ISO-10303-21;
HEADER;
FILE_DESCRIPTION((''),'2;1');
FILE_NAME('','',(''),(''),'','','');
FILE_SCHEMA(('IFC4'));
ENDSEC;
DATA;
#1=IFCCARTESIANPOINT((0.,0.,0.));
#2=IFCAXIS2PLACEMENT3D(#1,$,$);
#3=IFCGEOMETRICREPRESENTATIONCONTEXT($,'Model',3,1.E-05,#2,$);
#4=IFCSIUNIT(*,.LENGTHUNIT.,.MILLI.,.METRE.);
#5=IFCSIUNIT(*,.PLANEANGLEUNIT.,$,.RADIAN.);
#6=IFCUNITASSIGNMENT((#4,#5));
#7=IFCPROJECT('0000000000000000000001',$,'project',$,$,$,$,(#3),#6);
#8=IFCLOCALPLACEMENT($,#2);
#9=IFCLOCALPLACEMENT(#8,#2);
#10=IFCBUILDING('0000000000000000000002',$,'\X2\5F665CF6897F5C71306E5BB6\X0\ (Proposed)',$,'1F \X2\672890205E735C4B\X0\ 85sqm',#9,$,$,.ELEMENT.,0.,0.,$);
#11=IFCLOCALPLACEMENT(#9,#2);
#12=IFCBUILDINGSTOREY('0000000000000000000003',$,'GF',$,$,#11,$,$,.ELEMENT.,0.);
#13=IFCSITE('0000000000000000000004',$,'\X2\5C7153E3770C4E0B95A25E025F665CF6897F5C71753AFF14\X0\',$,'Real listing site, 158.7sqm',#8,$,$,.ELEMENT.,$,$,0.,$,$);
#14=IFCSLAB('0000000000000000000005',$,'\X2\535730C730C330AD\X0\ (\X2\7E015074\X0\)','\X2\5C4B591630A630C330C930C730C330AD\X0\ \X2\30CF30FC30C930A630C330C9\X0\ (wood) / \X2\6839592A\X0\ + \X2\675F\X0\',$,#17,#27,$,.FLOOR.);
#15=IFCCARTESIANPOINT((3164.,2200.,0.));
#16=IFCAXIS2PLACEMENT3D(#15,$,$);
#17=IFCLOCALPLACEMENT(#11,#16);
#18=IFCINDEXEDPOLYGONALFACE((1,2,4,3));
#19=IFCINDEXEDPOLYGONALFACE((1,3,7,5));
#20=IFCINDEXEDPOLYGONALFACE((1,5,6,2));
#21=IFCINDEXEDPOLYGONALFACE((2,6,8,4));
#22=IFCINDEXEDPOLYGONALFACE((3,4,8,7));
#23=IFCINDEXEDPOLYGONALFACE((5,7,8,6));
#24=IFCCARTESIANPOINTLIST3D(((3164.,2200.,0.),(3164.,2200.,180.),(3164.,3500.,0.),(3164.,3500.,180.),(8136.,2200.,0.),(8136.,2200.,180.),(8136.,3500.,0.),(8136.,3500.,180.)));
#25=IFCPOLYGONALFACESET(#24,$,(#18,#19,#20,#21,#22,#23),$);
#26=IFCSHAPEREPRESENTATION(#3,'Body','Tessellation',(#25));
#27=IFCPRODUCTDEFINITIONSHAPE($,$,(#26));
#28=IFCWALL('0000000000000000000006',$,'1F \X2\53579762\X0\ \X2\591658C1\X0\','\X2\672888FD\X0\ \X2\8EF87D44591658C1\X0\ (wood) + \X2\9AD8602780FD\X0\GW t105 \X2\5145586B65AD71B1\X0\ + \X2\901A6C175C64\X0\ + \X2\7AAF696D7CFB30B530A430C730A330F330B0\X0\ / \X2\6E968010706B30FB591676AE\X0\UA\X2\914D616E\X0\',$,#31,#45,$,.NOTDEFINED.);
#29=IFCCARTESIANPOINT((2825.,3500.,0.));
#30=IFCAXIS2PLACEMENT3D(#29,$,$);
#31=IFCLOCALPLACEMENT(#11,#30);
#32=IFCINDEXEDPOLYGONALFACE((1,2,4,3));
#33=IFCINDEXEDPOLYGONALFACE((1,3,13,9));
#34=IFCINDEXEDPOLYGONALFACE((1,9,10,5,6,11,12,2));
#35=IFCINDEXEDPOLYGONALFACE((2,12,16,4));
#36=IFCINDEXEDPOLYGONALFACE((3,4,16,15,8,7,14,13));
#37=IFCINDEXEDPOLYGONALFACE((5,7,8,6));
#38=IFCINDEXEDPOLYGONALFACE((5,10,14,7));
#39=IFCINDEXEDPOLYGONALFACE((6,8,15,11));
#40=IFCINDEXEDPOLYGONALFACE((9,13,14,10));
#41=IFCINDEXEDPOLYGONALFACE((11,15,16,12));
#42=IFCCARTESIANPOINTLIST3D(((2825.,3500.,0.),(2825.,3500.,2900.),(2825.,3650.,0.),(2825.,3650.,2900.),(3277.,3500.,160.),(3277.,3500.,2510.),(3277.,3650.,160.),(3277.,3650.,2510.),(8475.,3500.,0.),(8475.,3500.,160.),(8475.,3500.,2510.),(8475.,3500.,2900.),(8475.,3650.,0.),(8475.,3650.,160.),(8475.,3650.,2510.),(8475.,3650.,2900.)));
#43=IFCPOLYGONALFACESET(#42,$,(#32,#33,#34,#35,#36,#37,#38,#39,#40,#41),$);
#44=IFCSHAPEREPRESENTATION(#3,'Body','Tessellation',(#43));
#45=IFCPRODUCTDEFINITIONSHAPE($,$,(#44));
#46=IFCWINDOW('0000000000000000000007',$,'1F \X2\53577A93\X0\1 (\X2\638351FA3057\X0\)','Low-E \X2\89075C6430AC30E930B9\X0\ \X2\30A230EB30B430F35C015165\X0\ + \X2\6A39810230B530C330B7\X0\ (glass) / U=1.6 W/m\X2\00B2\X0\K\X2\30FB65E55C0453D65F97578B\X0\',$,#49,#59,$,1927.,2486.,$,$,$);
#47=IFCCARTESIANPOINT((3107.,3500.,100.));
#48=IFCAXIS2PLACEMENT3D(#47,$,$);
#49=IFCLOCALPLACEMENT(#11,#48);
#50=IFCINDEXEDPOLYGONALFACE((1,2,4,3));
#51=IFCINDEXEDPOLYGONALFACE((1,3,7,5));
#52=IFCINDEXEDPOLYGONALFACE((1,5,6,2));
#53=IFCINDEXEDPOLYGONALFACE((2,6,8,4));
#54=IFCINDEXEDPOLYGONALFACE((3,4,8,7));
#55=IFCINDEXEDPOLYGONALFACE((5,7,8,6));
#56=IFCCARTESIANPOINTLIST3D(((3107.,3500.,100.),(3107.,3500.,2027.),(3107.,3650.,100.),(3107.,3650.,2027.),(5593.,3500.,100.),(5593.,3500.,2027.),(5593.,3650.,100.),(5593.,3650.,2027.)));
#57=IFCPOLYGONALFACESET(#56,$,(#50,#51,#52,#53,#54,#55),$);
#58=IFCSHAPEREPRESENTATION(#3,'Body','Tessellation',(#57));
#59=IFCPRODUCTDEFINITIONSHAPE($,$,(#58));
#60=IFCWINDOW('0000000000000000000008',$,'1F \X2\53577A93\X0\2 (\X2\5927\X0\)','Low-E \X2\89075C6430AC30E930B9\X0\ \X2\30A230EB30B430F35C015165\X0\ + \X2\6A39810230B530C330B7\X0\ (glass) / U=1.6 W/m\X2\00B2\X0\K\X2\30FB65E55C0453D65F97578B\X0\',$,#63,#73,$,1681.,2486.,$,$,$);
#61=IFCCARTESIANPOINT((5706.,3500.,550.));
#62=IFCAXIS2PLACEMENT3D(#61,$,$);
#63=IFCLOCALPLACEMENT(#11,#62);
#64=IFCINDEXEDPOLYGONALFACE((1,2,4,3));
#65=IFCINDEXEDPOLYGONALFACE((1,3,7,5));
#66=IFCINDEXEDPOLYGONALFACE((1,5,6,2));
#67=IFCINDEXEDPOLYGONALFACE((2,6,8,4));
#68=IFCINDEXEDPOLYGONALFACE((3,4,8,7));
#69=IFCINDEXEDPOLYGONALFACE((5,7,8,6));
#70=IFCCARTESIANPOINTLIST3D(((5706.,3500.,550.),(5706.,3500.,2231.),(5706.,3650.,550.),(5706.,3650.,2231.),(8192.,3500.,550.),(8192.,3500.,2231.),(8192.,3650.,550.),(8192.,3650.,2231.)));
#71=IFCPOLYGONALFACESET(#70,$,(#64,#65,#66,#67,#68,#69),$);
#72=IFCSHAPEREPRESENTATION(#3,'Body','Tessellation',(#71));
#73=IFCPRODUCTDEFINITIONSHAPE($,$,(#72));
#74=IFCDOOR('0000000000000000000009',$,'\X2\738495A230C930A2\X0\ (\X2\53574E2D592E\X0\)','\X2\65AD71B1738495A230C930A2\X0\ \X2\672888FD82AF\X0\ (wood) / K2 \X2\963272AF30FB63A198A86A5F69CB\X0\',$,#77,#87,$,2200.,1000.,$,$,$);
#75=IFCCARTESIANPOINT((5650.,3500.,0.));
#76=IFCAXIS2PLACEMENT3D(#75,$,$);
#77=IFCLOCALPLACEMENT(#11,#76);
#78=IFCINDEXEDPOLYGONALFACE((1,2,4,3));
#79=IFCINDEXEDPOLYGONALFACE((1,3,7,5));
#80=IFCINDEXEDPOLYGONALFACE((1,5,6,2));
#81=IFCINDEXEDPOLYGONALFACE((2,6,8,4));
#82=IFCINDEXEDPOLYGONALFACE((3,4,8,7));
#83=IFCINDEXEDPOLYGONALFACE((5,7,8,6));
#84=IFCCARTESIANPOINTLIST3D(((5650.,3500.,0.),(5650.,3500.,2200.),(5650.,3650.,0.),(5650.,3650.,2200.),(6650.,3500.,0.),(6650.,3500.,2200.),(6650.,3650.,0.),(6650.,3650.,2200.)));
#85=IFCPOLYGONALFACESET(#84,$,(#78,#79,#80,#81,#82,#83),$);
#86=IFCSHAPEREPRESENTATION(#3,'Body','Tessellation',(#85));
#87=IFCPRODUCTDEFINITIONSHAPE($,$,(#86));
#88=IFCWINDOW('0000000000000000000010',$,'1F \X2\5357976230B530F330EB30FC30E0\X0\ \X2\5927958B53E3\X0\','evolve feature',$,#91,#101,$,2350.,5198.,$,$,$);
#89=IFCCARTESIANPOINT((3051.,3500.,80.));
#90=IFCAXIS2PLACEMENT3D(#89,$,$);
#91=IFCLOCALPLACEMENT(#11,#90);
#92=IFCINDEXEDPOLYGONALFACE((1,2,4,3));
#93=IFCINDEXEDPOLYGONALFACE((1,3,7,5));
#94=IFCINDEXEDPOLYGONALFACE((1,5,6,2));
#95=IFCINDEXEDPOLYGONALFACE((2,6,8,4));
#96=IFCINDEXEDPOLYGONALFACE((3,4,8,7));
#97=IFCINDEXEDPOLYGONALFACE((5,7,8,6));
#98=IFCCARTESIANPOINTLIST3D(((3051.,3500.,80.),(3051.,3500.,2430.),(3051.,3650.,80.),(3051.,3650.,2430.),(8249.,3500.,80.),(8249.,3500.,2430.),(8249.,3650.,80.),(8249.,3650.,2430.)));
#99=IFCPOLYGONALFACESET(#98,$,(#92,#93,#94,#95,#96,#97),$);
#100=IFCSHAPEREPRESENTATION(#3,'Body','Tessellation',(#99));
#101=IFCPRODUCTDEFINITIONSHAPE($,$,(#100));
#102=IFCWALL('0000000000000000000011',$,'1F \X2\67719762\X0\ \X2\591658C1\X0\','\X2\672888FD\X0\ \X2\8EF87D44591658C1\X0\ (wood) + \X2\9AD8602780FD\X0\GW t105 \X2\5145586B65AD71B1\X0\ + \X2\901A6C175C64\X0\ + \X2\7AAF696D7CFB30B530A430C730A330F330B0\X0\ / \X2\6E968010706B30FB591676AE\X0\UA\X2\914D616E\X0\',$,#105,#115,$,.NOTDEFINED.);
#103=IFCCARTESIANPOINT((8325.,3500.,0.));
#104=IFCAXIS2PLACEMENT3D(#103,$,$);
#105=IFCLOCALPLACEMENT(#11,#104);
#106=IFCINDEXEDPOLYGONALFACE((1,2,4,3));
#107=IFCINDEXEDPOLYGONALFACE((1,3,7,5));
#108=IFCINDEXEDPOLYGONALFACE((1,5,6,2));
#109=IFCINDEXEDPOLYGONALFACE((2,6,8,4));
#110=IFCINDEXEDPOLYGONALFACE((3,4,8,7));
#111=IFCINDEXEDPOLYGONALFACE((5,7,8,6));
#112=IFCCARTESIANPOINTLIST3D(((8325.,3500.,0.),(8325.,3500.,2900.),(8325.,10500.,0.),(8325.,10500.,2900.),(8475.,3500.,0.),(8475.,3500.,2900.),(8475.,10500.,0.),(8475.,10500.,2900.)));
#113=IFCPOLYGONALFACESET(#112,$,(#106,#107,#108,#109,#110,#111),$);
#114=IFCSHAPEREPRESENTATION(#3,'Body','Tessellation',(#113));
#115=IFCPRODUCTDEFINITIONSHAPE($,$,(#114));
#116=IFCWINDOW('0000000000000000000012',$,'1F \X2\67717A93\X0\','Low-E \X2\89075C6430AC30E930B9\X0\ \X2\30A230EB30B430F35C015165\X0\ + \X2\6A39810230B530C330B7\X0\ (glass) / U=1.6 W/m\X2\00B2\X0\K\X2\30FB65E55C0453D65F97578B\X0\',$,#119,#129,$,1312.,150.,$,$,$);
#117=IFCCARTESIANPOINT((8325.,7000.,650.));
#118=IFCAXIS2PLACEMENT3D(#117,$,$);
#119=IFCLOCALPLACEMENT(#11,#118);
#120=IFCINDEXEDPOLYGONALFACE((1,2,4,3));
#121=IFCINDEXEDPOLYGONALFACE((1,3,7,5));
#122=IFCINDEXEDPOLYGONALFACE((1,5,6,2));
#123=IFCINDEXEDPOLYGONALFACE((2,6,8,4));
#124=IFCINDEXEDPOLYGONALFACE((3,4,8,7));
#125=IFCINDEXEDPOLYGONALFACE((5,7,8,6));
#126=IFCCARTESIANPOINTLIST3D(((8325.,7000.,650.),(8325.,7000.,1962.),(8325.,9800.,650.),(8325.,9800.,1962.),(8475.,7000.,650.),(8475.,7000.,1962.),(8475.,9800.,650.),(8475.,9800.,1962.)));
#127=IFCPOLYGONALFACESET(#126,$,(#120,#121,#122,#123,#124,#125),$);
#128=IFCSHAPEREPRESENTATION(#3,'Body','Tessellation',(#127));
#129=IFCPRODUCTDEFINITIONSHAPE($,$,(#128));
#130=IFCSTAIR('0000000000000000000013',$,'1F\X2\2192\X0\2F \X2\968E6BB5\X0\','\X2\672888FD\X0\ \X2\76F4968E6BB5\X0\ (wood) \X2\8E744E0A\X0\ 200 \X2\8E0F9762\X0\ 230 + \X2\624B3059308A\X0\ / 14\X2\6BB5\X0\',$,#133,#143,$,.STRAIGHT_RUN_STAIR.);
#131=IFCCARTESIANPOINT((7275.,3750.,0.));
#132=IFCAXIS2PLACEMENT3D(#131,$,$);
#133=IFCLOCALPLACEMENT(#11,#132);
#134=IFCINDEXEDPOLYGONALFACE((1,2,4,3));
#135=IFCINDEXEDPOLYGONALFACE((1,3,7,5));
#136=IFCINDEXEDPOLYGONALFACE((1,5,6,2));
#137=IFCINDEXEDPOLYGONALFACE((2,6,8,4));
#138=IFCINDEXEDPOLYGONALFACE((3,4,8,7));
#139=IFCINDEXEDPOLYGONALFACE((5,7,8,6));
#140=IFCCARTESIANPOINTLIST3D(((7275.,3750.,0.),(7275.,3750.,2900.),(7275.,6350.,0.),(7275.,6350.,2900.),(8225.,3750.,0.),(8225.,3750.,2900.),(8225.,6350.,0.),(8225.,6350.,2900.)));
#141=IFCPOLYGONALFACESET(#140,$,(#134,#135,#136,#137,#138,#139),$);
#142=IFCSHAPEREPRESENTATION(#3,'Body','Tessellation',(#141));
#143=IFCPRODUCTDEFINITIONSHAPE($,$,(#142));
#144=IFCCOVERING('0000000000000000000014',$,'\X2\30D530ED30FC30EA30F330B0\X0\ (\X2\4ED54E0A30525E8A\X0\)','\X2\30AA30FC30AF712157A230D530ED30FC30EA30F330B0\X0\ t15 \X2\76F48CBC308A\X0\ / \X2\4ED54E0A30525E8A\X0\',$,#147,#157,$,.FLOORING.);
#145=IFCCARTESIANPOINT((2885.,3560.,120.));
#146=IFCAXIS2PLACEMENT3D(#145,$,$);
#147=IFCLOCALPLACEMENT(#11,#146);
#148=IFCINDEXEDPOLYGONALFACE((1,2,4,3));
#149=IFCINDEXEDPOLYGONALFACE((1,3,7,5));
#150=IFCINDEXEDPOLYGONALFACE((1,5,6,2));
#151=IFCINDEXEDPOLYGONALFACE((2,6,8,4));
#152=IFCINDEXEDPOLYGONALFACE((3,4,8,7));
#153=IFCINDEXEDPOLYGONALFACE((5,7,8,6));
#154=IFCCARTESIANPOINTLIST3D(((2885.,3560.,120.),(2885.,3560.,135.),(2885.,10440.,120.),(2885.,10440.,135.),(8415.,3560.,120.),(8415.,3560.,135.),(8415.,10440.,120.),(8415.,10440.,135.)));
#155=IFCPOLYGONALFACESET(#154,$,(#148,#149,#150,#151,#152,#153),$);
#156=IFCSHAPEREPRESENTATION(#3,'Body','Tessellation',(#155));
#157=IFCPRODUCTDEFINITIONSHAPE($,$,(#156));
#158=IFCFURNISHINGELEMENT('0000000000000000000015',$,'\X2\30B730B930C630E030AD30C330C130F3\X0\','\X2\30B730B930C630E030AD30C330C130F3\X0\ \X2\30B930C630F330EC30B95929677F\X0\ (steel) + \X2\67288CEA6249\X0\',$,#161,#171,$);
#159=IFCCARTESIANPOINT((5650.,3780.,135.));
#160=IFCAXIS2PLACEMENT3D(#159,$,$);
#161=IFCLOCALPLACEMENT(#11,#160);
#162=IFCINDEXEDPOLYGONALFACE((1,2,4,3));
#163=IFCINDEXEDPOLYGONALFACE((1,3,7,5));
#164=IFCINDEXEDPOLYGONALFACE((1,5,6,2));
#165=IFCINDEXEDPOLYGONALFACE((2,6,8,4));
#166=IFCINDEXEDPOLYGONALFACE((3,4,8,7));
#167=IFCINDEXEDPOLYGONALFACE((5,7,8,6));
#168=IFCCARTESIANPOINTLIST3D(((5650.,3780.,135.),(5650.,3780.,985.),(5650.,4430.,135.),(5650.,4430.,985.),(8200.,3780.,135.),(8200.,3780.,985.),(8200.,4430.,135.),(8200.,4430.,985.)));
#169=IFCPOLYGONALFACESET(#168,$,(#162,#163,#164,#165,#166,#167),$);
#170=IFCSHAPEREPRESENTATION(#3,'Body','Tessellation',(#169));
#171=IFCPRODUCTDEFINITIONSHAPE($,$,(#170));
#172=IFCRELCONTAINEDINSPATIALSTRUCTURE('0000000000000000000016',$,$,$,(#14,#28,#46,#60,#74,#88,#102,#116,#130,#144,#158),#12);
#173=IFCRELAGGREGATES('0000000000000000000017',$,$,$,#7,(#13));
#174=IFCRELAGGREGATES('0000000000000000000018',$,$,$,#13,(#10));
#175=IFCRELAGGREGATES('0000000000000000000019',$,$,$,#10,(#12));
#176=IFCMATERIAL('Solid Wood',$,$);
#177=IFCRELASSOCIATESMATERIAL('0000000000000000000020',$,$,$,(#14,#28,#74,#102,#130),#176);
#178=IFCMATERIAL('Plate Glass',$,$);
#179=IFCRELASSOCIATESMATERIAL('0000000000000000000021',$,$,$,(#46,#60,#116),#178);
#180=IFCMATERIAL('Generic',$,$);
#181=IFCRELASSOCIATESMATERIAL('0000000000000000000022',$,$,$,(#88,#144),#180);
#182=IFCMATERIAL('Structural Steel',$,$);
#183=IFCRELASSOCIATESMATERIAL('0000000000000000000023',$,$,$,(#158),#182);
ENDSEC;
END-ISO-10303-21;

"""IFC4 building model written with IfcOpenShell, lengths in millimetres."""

from ifc_helpers import new_model, si_unit, frame, frame_2d, origin, place, context, project, spatial, rectangle, extrude, material, element, fill, save


model = new_model("IFC4")

# Units and contexts
model_context = context("Model", 3, precision=1e-05, world=origin())
ifc_project = project(units=[si_unit("LENGTHUNIT", "METRE", prefix="MILLI"), si_unit("PLANEANGLEUNIT", "RADIAN")], contexts=[model_context])

# Site, building, storey
site_placement = place(None, origin())
site = spatial("IfcSite", under=ifc_project, at=site_placement, Name="山口県下関市彦島西山町４", ObjectType="Real listing site, 158.7sqm", CompositionType="ELEMENT", RefElevation=0.0)
building_placement = place(site_placement, origin())
building = spatial("IfcBuilding", under=site, at=building_placement, Name="彦島西山の家 (Proposed)", ObjectType="1F 木造平屋 85sqm", CompositionType="ELEMENT", ElevationOfRefHeight=0.0, ElevationOfTerrain=0.0)
storey_placement = place(building_placement, origin())
storey = spatial("IfcBuildingStorey", under=building, at=storey_placement, Name="GF", CompositionType="ELEMENT", Elevation=0.0)

# Slab
ifc_material_1 = material(Name="Solid Wood")
slab_1_placement = place(storey_placement, frame((3164.0, 2200.0, 0.0)))
element("IfcSlab", 1, at=slab_1_placement, inside=storey, material=ifc_material_1, Name="南デッキ (縁側)", Description="屋外ウッドデッキ ハードウッド (wood) / 根太 + 束", PredefinedType="FLOOR", context=model_context, shape_type="SweptSolid", body=[
    extrude(rectangle(XDim=4972.0, YDim=1300.0, at=frame_2d((2486.0, 650.0))), frame((3164.0, 2200.0, 0.0)), (0.0, 0.0, 1.0), 180.0),
])
ifc_material_2 = material(Name="Generic")

# Wall, openings, windows, door
wall_1_placement = place(storey_placement, frame((2825.0, 3500.0, 0.0)))
wall_1 = element("IfcWall", 2, at=wall_1_placement, inside=storey, material=ifc_material_1, Name="1F 南面 外壁", Description="木製 軸組外壁 (wood) + 高性能GW t105 充填断熱 + 通気層 + 窯業系サイディング / 準耐火・外皮UA配慮", PredefinedType="NOTDEFINED", context=model_context, shape_type="SweptSolid", body=[
    extrude(rectangle(XDim=5650.0, YDim=150.0, at=frame_2d((2825.0, 75.0))), frame((2825.0, 3500.0, 0.0)), (0.0, 0.0, 1.0), 2900.0),
])
opening_1_placement = place(storey_placement, frame((3107.0, 3500.0, 100.0)))
opening_1 = element("IfcOpeningElement", 3, at=opening_1_placement, cuts=wall_1, PredefinedType="NOTDEFINED", context=model_context, shape_type="SweptSolid", body=[
    extrude(rectangle(XDim=2486.0, YDim=150.0, at=frame_2d((1243.0, 75.0))), frame((3107.0, 3500.0, 100.0)), (0.0, 0.0, 1.0), 1927.0),
])
opening_2_placement = place(storey_placement, frame((5706.0, 3500.0, 550.0)))
opening_2 = element("IfcOpeningElement", 4, at=opening_2_placement, cuts=wall_1, PredefinedType="NOTDEFINED", context=model_context, shape_type="SweptSolid", body=[
    extrude(rectangle(XDim=2486.0, YDim=150.0, at=frame_2d((1243.0, 75.0))), frame((5706.0, 3500.0, 550.0)), (0.0, 0.0, 1.0), 1681.0),
])
opening_3_placement = place(storey_placement, frame((5650.0, 3500.0, 0.0)))
opening_3 = element("IfcOpeningElement", 5, at=opening_3_placement, cuts=wall_1, PredefinedType="NOTDEFINED", context=model_context, shape_type="SweptSolid", body=[
    extrude(rectangle(XDim=1000.0, YDim=150.0, at=frame_2d((500.0, 75.0))), frame((5650.0, 3500.0, 0.0)), (0.0, 0.0, 1.0), 2200.0),
])
opening_4_placement = place(storey_placement, frame((3051.0, 3500.0, 80.0)))
opening_4 = element("IfcOpeningElement", 6, at=opening_4_placement, cuts=wall_1, PredefinedType="NOTDEFINED", context=model_context, shape_type="SweptSolid", body=[
    extrude(rectangle(XDim=5198.0, YDim=150.0, at=frame_2d((2599.0, 75.0))), frame((3051.0, 3500.0, 80.0)), (0.0, 0.0, 1.0), 2350.0),
])
ifc_material_3 = material(Name="Plate Glass")
window_1_placement = place(storey_placement, frame((3107.0, 3500.0, 100.0)))
window_1 = element("IfcWindow", 7, at=window_1_placement, inside=storey, material=ifc_material_3, Name="1F 南窓1 (掃出し)", Description="Low-E 複層ガラス アルゴン封入 + 樹脂サッシ (glass) / U=1.6 W/m²K・日射取得型", OverallHeight=1927.0, OverallWidth=2486.0, context=model_context, shape_type="SweptSolid", body=[
    extrude(rectangle(XDim=2486.0, YDim=150.0, at=frame_2d((1243.0, 75.0))), frame((3107.0, 3500.0, 100.0)), (0.0, 0.0, 1.0), 1927.0),
])
fill(opening_1, window_1)
window_2_placement = place(storey_placement, frame((5706.0, 3500.0, 550.0)))
window_2 = element("IfcWindow", 8, at=window_2_placement, inside=storey, material=ifc_material_3, Name="1F 南窓2 (大)", Description="Low-E 複層ガラス アルゴン封入 + 樹脂サッシ (glass) / U=1.6 W/m²K・日射取得型", OverallHeight=1681.0, OverallWidth=2486.0, context=model_context, shape_type="SweptSolid", body=[
    extrude(rectangle(XDim=2486.0, YDim=150.0, at=frame_2d((1243.0, 75.0))), frame((5706.0, 3500.0, 550.0)), (0.0, 0.0, 1.0), 1681.0),
])
fill(opening_2, window_2)
door_placement = place(storey_placement, frame((5650.0, 3500.0, 0.0)))
door = element("IfcDoor", 9, at=door_placement, inside=storey, material=ifc_material_1, Name="玄関ドア (南中央)", Description="断熱玄関ドア 木製芯 (wood) / K2 防犯・採風機構", OverallHeight=2200.0, OverallWidth=1000.0, context=model_context, shape_type="SweptSolid", body=[
    extrude(rectangle(XDim=1000.0, YDim=150.0, at=frame_2d((500.0, 75.0))), frame((5650.0, 3500.0, 0.0)), (0.0, 0.0, 1.0), 2200.0),
])
fill(opening_3, door)
window_3_placement = place(storey_placement, frame((3051.0, 3500.0, 80.0)))
window_3 = element("IfcWindow", 10, at=window_3_placement, inside=storey, material=ifc_material_2, Name="1F 南面サンルーム 大開口", Description="evolve feature", OverallHeight=2350.0, OverallWidth=5198.0, context=model_context, shape_type="SweptSolid", body=[
    extrude(rectangle(XDim=5198.0, YDim=150.0, at=frame_2d((2599.0, 75.0))), frame((3051.0, 3500.0, 80.0)), (0.0, 0.0, 1.0), 2350.0),
])
fill(opening_4, window_3)

# Wall, opening, window
wall_2_placement = place(storey_placement, frame((8325.0, 3500.0, 0.0)))
wall_2 = element("IfcWall", 11, at=wall_2_placement, inside=storey, material=ifc_material_1, Name="1F 東面 外壁", Description="木製 軸組外壁 (wood) + 高性能GW t105 充填断熱 + 通気層 + 窯業系サイディング / 準耐火・外皮UA配慮", PredefinedType="NOTDEFINED", context=model_context, shape_type="SweptSolid", body=[
    extrude(rectangle(XDim=150.0, YDim=7000.0, at=frame_2d((75.0, 3500.0))), frame((8325.0, 3500.0, 0.0)), (0.0, 0.0, 1.0), 2900.0),
])
opening_5_placement = place(storey_placement, frame((8325.0, 7000.0, 650.0)))
opening_5 = element("IfcOpeningElement", 12, at=opening_5_placement, cuts=wall_2, PredefinedType="NOTDEFINED", context=model_context, shape_type="SweptSolid", body=[
    extrude(rectangle(XDim=150.0, YDim=2800.0, at=frame_2d((75.0, 1400.0))), frame((8325.0, 7000.0, 650.0)), (0.0, 0.0, 1.0), 1312.0),
])
window_4_placement = place(storey_placement, frame((8325.0, 7000.0, 650.0)))
window_4 = element("IfcWindow", 13, at=window_4_placement, inside=storey, material=ifc_material_3, Name="1F 東窓", Description="Low-E 複層ガラス アルゴン封入 + 樹脂サッシ (glass) / U=1.6 W/m²K・日射取得型", OverallHeight=1312.0, OverallWidth=150.0, context=model_context, shape_type="SweptSolid", body=[
    extrude(rectangle(XDim=150.0, YDim=2800.0, at=frame_2d((75.0, 1400.0))), frame((8325.0, 7000.0, 650.0)), (0.0, 0.0, 1.0), 1312.0),
])
fill(opening_5, window_4)

# Stair
stair_placement = place(storey_placement, frame((7275.0, 3750.0, 0.0)))
element("IfcStair", 14, at=stair_placement, inside=storey, material=ifc_material_1, Name="1F→2F 階段", Description="木製 直階段 (wood) 蹴上 200 踏面 230 + 手すり / 14段", PredefinedType="STRAIGHT_RUN_STAIR", context=model_context, shape_type="SweptSolid", body=[
    extrude(rectangle(XDim=950.0, YDim=2600.0, at=frame_2d((475.0, 1300.0))), frame((7275.0, 3750.0, 0.0)), (0.0, 0.0, 1.0), 2900.0),
])

# Covering
covering_placement = place(storey_placement, frame((2885.0, 3560.0, 120.0)))
element("IfcCovering", 15, at=covering_placement, inside=storey, material=ifc_material_2, Name="フローリング (仕上げ床)", Description="オーク無垢フローリング t15 直貼り / 仕上げ床", PredefinedType="FLOORING", context=model_context, shape_type="SweptSolid", body=[
    extrude(rectangle(XDim=5530.0, YDim=6880.0, at=frame_2d((2765.0, 3440.0))), frame((2885.0, 3560.0, 120.0)), (0.0, 0.0, 1.0), 15.0),
])

# Furnishing element
ifc_material_4 = material(Name="Structural Steel")
furnishing_placement = place(storey_placement, frame((5650.0, 3780.0, 135.0)))
element("IfcFurnishingElement", 16, at=furnishing_placement, inside=storey, material=ifc_material_4, Name="システムキッチン", Description="システムキッチン ステンレス天板 (steel) + 木質扉", context=model_context, shape_type="SweptSolid", body=[
    extrude(rectangle(XDim=2550.0, YDim=650.0, at=frame_2d((1275.0, 325.0))), frame((5650.0, 3780.0, 135.0)), (0.0, 0.0, 1.0), 850.0),
])

save(model, "model.ifc")
